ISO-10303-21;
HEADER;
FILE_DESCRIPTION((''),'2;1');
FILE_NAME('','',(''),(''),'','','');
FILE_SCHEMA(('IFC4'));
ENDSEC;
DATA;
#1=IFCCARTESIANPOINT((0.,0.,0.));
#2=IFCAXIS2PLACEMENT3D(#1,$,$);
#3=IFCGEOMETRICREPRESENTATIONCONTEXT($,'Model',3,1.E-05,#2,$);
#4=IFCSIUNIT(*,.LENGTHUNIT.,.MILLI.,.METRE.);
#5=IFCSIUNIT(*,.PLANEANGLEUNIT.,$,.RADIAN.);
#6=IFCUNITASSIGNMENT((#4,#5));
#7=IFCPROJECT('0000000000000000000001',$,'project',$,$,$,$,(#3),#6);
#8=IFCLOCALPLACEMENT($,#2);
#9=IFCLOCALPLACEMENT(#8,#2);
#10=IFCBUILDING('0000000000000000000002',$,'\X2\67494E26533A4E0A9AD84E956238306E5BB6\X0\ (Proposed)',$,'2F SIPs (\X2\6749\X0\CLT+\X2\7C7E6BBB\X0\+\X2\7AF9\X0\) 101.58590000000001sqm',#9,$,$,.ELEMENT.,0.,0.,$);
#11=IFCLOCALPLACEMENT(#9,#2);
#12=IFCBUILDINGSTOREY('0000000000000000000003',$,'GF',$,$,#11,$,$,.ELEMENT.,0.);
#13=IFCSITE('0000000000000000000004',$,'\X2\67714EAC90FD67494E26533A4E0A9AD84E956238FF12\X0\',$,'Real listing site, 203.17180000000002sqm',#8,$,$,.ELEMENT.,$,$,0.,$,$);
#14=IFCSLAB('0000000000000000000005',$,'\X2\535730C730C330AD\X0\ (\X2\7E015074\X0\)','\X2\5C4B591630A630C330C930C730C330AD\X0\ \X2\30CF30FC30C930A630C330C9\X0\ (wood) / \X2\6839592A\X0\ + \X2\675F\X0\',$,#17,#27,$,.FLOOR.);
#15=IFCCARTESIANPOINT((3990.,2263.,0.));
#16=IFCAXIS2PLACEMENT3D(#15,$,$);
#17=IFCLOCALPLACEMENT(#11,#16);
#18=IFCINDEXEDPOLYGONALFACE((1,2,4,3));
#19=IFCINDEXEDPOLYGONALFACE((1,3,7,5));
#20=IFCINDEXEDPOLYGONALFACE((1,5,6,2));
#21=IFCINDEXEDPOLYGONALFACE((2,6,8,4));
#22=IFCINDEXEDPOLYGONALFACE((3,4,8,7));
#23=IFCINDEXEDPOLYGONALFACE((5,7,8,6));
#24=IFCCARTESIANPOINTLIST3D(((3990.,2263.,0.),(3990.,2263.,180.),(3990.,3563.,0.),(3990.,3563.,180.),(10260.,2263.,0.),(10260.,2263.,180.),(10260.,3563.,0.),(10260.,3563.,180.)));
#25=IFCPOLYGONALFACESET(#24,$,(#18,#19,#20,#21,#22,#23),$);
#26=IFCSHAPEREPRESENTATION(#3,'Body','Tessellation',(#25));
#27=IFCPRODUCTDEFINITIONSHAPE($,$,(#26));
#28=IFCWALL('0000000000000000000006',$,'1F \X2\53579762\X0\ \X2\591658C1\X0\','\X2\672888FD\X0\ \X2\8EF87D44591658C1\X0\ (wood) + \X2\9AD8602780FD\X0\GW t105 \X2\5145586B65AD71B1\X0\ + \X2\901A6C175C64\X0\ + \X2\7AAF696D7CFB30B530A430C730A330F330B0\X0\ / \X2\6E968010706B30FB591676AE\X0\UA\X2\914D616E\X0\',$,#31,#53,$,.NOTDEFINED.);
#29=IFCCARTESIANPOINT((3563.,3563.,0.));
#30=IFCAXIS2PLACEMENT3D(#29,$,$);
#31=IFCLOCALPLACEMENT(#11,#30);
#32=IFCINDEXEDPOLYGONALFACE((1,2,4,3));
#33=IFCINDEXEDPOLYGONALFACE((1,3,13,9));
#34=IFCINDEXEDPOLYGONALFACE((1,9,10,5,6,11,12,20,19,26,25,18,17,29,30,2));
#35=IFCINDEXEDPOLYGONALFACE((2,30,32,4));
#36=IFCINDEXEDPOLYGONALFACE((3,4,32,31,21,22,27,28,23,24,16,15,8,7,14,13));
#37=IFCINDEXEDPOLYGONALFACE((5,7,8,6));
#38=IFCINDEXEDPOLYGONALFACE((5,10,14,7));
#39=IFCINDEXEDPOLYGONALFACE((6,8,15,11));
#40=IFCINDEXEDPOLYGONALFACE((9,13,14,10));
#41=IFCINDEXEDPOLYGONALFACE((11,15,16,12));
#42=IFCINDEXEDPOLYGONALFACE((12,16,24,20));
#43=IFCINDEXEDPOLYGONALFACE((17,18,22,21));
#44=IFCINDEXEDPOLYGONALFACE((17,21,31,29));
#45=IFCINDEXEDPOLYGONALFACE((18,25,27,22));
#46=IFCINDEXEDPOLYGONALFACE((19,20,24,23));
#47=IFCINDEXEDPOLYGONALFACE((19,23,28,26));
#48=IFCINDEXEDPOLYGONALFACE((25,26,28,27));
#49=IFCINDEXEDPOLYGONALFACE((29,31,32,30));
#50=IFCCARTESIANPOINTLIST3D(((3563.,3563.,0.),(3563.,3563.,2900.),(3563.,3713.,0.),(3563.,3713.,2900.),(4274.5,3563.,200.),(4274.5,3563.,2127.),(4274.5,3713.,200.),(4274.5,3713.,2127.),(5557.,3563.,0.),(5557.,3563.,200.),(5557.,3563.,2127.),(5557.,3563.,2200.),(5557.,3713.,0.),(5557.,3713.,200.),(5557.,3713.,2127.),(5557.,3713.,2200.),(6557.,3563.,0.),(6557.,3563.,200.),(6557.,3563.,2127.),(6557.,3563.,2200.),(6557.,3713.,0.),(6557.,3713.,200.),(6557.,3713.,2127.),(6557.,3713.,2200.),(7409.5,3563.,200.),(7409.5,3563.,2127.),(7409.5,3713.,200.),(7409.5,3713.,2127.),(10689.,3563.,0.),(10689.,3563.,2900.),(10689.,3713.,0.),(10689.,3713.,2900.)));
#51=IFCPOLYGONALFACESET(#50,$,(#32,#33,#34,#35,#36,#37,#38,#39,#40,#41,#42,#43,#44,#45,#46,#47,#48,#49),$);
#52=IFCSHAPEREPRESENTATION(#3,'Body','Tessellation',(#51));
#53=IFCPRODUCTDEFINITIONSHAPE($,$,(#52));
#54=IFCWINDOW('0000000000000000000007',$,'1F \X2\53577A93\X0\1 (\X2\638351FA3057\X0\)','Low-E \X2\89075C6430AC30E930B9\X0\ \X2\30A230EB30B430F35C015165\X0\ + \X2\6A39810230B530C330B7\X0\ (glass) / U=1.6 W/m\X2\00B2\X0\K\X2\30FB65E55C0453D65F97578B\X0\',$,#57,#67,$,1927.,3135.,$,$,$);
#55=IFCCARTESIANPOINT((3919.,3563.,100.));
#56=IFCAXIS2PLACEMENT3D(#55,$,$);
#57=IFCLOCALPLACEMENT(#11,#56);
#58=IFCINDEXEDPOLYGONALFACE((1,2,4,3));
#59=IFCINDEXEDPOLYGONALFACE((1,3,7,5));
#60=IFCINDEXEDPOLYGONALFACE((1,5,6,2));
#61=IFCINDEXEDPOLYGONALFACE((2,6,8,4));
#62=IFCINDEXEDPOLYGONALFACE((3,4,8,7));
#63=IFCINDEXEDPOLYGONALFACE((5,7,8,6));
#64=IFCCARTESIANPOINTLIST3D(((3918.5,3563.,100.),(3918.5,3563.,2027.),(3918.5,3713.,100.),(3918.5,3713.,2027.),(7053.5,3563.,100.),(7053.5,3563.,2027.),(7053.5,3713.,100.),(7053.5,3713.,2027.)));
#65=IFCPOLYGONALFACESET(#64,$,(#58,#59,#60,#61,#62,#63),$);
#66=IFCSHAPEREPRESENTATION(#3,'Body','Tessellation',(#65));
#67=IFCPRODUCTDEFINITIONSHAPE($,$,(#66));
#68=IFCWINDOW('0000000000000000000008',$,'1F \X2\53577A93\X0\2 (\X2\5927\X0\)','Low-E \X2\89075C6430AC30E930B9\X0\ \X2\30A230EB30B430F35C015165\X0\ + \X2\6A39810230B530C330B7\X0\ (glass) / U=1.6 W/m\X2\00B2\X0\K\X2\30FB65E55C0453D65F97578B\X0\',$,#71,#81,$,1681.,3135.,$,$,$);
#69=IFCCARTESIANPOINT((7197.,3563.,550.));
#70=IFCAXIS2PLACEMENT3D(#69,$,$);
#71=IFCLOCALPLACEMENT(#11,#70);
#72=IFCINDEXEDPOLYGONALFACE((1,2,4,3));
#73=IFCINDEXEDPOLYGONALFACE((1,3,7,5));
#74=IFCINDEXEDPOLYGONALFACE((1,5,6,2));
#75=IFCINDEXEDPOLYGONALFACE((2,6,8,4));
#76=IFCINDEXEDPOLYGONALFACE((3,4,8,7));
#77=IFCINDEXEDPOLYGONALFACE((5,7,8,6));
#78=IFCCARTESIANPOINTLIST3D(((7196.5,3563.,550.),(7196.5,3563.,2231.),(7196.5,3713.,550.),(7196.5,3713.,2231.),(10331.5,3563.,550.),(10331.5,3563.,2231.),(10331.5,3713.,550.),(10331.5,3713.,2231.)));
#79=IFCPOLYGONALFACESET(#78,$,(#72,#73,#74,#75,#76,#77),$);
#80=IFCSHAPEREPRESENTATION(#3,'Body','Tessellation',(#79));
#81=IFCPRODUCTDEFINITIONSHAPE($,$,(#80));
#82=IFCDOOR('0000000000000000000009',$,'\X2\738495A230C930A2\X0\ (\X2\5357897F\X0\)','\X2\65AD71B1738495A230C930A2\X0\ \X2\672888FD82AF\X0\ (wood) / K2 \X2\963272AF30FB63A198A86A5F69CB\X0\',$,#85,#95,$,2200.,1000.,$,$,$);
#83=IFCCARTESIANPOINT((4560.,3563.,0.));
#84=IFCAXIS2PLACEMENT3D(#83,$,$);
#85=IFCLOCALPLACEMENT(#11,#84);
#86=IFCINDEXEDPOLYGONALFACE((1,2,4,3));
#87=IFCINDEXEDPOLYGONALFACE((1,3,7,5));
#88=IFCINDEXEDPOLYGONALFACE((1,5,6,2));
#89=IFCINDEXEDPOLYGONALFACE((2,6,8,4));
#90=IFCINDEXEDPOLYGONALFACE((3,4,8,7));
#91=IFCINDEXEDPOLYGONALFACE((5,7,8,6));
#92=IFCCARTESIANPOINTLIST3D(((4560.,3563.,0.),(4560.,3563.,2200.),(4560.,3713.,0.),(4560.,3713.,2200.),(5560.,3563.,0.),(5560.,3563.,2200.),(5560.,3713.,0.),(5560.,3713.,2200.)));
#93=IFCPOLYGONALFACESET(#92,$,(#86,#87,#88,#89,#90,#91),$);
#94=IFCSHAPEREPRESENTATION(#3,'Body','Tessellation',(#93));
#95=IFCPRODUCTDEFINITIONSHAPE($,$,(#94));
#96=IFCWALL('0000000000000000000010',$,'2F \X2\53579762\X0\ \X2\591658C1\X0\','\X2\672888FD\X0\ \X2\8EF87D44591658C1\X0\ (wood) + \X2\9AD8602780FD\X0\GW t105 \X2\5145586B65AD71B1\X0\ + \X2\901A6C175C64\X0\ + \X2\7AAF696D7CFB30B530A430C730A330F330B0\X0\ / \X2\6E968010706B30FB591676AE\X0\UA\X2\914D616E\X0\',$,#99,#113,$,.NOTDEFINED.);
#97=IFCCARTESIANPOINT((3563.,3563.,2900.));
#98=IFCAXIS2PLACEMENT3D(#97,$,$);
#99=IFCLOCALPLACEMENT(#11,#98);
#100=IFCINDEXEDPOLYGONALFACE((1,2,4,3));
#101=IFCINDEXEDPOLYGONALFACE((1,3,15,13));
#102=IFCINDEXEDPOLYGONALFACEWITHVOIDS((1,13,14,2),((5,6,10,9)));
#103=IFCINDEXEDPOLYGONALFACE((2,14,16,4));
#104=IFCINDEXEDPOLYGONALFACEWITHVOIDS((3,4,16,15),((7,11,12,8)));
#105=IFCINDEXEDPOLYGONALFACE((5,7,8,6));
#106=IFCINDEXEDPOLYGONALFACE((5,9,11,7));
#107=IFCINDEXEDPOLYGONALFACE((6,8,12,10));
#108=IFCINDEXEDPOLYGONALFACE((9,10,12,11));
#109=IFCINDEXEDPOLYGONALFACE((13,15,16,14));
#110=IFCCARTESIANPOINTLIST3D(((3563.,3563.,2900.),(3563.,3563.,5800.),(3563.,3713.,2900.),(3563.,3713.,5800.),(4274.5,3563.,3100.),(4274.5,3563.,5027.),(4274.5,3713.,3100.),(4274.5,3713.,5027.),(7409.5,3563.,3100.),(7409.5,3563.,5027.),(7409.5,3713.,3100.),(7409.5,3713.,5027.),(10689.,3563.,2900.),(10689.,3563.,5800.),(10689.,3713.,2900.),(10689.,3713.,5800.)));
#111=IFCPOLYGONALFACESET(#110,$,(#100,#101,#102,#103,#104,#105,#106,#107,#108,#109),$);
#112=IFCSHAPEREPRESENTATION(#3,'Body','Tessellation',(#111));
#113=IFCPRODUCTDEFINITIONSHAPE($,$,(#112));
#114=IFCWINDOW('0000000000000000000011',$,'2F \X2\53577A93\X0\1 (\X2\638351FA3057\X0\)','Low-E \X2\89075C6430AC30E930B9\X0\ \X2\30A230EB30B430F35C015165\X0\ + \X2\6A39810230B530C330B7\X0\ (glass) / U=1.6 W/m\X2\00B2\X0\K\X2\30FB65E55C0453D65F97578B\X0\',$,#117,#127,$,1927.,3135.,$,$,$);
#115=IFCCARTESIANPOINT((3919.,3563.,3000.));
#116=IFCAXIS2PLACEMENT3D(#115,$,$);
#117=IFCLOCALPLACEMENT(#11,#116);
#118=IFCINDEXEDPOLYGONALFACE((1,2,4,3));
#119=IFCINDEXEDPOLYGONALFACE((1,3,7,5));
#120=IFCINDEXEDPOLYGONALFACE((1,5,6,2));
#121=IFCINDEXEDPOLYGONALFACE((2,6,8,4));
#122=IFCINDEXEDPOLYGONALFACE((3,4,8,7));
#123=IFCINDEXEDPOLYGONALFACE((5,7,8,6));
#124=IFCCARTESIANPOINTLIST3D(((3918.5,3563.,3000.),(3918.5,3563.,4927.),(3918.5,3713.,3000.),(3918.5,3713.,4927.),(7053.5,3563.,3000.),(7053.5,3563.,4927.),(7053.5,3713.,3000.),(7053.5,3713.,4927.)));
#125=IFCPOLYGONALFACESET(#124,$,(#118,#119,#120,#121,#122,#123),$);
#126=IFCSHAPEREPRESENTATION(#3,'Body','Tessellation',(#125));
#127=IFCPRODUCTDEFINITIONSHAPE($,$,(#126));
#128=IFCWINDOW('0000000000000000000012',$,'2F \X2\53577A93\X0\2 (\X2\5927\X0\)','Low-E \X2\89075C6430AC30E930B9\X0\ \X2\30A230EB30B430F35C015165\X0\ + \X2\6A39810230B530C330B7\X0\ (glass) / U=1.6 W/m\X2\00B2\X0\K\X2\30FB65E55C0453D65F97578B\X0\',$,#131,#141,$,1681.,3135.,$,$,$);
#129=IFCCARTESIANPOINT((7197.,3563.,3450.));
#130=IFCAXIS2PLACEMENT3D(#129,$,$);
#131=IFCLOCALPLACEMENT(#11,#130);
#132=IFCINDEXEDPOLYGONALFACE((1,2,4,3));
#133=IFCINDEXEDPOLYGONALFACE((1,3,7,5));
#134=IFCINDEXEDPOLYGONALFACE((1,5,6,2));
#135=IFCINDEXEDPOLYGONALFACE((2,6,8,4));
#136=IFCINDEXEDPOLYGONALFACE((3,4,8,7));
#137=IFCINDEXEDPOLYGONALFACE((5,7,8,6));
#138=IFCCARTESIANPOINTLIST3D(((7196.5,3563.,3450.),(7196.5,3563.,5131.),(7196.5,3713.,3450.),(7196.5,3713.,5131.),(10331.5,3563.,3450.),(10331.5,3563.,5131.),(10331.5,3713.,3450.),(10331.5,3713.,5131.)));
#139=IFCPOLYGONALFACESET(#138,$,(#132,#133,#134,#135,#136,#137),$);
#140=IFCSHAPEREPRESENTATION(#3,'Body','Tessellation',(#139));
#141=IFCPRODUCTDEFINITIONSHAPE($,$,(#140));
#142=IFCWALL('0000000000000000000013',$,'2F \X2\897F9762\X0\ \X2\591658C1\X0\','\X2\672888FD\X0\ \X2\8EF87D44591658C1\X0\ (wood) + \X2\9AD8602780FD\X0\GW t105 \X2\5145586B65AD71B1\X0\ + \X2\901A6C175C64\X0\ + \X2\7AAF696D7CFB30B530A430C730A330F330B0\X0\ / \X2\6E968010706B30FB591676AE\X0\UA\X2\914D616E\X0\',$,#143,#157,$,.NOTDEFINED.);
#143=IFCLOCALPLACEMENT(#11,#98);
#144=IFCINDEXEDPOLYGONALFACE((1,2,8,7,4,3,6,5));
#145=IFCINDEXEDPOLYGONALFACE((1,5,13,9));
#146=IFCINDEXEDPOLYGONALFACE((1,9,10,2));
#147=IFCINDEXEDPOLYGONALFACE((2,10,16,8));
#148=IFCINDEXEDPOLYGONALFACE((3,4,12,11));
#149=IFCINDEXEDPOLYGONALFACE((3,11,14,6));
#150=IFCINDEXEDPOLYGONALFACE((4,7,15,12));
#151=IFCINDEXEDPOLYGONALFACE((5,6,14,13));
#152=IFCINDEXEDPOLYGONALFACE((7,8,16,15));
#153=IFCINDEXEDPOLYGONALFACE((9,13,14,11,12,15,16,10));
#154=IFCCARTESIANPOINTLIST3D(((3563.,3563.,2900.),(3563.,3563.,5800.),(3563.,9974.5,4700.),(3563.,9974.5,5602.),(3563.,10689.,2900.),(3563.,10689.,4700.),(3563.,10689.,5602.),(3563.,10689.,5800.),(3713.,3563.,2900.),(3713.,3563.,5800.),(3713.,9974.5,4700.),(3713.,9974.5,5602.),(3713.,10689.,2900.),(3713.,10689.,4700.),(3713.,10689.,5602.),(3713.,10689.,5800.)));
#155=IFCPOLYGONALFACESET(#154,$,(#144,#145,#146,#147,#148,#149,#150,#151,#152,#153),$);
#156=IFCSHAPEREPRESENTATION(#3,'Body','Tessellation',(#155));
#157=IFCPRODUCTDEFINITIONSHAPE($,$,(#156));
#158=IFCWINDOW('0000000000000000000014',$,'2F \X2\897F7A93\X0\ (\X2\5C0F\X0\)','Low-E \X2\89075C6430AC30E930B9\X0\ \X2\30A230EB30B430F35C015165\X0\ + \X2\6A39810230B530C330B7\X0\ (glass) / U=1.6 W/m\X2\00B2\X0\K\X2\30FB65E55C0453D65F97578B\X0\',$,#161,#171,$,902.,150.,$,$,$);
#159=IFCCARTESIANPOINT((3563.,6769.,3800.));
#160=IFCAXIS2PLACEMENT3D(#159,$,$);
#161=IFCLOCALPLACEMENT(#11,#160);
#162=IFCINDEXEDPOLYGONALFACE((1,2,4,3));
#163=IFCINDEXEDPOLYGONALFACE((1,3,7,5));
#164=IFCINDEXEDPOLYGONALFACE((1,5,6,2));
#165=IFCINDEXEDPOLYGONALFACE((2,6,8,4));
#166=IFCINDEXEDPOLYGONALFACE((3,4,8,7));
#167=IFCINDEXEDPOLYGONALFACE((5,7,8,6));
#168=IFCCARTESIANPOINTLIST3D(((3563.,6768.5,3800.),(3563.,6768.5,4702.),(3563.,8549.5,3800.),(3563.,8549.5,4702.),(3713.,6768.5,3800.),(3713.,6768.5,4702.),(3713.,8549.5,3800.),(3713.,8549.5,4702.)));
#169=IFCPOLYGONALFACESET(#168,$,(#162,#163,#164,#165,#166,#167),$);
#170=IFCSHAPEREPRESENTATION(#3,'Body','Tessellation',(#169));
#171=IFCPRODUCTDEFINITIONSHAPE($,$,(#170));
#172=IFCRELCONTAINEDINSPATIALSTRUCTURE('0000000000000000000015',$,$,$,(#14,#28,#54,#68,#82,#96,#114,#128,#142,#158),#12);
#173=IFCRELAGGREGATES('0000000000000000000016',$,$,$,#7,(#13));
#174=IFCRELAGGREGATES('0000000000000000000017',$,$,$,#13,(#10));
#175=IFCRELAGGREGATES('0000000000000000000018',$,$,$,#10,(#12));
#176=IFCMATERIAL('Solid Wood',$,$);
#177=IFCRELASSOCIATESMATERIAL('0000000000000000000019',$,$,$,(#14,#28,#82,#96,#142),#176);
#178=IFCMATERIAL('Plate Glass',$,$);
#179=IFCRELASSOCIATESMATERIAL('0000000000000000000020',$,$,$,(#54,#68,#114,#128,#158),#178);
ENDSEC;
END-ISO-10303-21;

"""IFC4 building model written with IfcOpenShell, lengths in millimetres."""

from ifc_helpers import new_model, si_unit, frame, frame_2d, origin, place, context, project, spatial, rectangle, extrude, material, element, fill, save


model = new_model("IFC4")

# Units and contexts
model_context = context("Model", 3, precision=1e-05, world=origin())
ifc_project = project(units=[si_unit("LENGTHUNIT", "METRE", prefix="MILLI"), si_unit("PLANEANGLEUNIT", "RADIAN")], contexts=[model_context])

# Site, building, storey
site_placement = place(None, origin())
site = spatial("IfcSite", under=ifc_project, at=site_placement, Name="東京都杉並区上高井戸２", ObjectType="Real listing site, 203.17180000000002sqm", CompositionType="ELEMENT", RefElevation=0.0)
building_placement = place(site_placement, origin())
building = spatial("IfcBuilding", under=site, at=building_placement, Name="杉並区上高井戸の家 (Proposed)", ObjectType="2F SIPs (杉CLT+籾殻+竹) 101.58590000000001sqm", CompositionType="ELEMENT", ElevationOfRefHeight=0.0, ElevationOfTerrain=0.0)
storey_placement = place(building_placement, origin())
storey = spatial("IfcBuildingStorey", under=building, at=storey_placement, Name="GF", CompositionType="ELEMENT", Elevation=0.0)

# Slab
ifc_material_1 = material(Name="Solid Wood")
slab_1_placement = place(storey_placement, frame((3990.0, 2263.0, 0.0)))
element("IfcSlab", 1, at=slab_1_placement, inside=storey, material=ifc_material_1, Name="南デッキ (縁側)", Description="屋外ウッドデッキ ハードウッド (wood) / 根太 + 束", PredefinedType="FLOOR", context=model_context, shape_type="SweptSolid", body=[
    extrude(rectangle(XDim=6270.0, YDim=1300.0, at=frame_2d((3135.0, 650.0))), frame((3990.0, 2263.0, 0.0)), (0.0, 0.0, 1.0), 180.0),
])

# Wall, openings, windows, door
wall_1_placement = place(storey_placement, frame((3563.0, 3563.0, 0.0)))
wall_1 = element("IfcWall", 2, at=wall_1_placement, inside=storey, material=ifc_material_1, Name="1F 南面 外壁", Description="木製 軸組外壁 (wood) + 高性能GW t105 充填断熱 + 通気層 + 窯業系サイディング / 準耐火・外皮UA配慮", PredefinedType="NOTDEFINED", context=model_context, shape_type="SweptSolid", body=[
    extrude(rectangle(XDim=7126.0, YDim=150.0, at=frame_2d((3563.0, 75.0))), frame((3563.0, 3563.0, 0.0)), (0.0, 0.0, 1.0), 2900.0),
])
opening_1_placement = place(storey_placement, frame((3919.0, 3563.0, 100.0)))
opening_1 = element("IfcOpeningElement", 3, at=opening_1_placement, cuts=wall_1, PredefinedType="NOTDEFINED", context=model_context, shape_type="SweptSolid", body=[
    extrude(rectangle(XDim=3135.0, YDim=150.0, at=frame_2d((1567.0, 75.0))), frame((3919.0, 3563.0, 100.0)), (0.0, 0.0, 1.0), 1927.0),
])
opening_2_placement = place(storey_placement, frame((7197.0, 3563.0, 550.0)))
opening_2 = element("IfcOpeningElement", 4, at=opening_2_placement, cuts=wall_1, PredefinedType="NOTDEFINED", context=model_context, shape_type="SweptSolid", body=[
    extrude(rectangle(XDim=3135.0, YDim=150.0, at=frame_2d((1567.0, 75.0))), frame((7197.0, 3563.0, 550.0)), (0.0, 0.0, 1.0), 1681.0),
])
opening_3_placement = place(storey_placement, frame((4560.0, 3563.0, 0.0)))
opening_3 = element("IfcOpeningElement", 5, at=opening_3_placement, cuts=wall_1, PredefinedType="NOTDEFINED", context=model_context, shape_type="SweptSolid", body=[
    extrude(rectangle(XDim=1000.0, YDim=150.0, at=frame_2d((500.0, 75.0))), frame((4560.0, 3563.0, 0.0)), (0.0, 0.0, 1.0), 2200.0),
])
ifc_material_2 = material(Name="Plate Glass")
window_1_placement = place(storey_placement, frame((3919.0, 3563.0, 100.0)))
window_1 = element("IfcWindow", 6, at=window_1_placement, inside=storey, material=ifc_material_2, Name="1F 南窓1 (掃出し)", Description="Low-E 複層ガラス アルゴン封入 + 樹脂サッシ (glass) / U=1.6 W/m²K・日射取得型", OverallHeight=1927.0, OverallWidth=3135.0, context=model_context, shape_type="SweptSolid", body=[
    extrude(rectangle(XDim=3135.0, YDim=150.0, at=frame_2d((1567.0, 75.0))), frame((3919.0, 3563.0, 100.0)), (0.0, 0.0, 1.0), 1927.0),
])
fill(opening_1, window_1)
window_2_placement = place(storey_placement, frame((7197.0, 3563.0, 550.0)))
window_2 = element("IfcWindow", 7, at=window_2_placement, inside=storey, material=ifc_material_2, Name="1F 南窓2 (大)", Description="Low-E 複層ガラス アルゴン封入 + 樹脂サッシ (glass) / U=1.6 W/m²K・日射取得型", OverallHeight=1681.0, OverallWidth=3135.0, context=model_context, shape_type="SweptSolid", body=[
    extrude(rectangle(XDim=3135.0, YDim=150.0, at=frame_2d((1567.0, 75.0))), frame((7197.0, 3563.0, 550.0)), (0.0, 0.0, 1.0), 1681.0),
])
fill(opening_2, window_2)
door_placement = place(storey_placement, frame((4560.0, 3563.0, 0.0)))
door = element("IfcDoor", 8, at=door_placement, inside=storey, material=ifc_material_1, Name="玄関ドア (南西)", Description="断熱玄関ドア 木製芯 (wood) / K2 防犯・採風機構", OverallHeight=2200.0, OverallWidth=1000.0, context=model_context, shape_type="SweptSolid", body=[
    extrude(rectangle(XDim=1000.0, YDim=150.0, at=frame_2d((500.0, 75.0))), frame((4560.0, 3563.0, 0.0)), (0.0, 0.0, 1.0), 2200.0),
])
fill(opening_3, door)

# Wall, openings, windows
wall_2_placement = place(storey_placement, frame((3563.0, 3563.0, 2900.0)))
wall_2 = element("IfcWall", 9, at=wall_2_placement, inside=storey, material=ifc_material_1, Name="2F 南面 外壁", Description="木製 軸組外壁 (wood) + 高性能GW t105 充填断熱 + 通気層 + 窯業系サイディング / 準耐火・外皮UA配慮", PredefinedType="NOTDEFINED", context=model_context, shape_type="SweptSolid", body=[
    extrude(rectangle(XDim=7126.0, YDim=150.0, at=frame_2d((3563.0, 75.0))), frame((3563.0, 3563.0, 2900.0)), (0.0, 0.0, 1.0), 2900.0),
])
opening_4_placement = place(storey_placement, frame((3919.0, 3563.0, 3000.0)))
opening_4 = element("IfcOpeningElement", 10, at=opening_4_placement, cuts=wall_2, PredefinedType="NOTDEFINED", context=model_context, shape_type="SweptSolid", body=[
    extrude(rectangle(XDim=3135.0, YDim=150.0, at=frame_2d((1567.0, 75.0))), frame((3919.0, 3563.0, 3000.0)), (0.0, 0.0, 1.0), 1927.0),
])
opening_5_placement = place(storey_placement, frame((7197.0, 3563.0, 3450.0)))
opening_5 = element("IfcOpeningElement", 11, at=opening_5_placement, cuts=wall_2, PredefinedType="NOTDEFINED", context=model_context, shape_type="SweptSolid", body=[
    extrude(rectangle(XDim=3135.0, YDim=150.0, at=frame_2d((1567.0, 75.0))), frame((7197.0, 3563.0, 3450.0)), (0.0, 0.0, 1.0), 1681.0),
])
window_3_placement = place(storey_placement, frame((3919.0, 3563.0, 3000.0)))
window_3 = element("IfcWindow", 12, at=window_3_placement, inside=storey, material=ifc_material_2, Name="2F 南窓1 (掃出し)", Description="Low-E 複層ガラス アルゴン封入 + 樹脂サッシ (glass) / U=1.6 W/m²K・日射取得型", OverallHeight=1927.0, OverallWidth=3135.0, context=model_context, shape_type="SweptSolid", body=[
    extrude(rectangle(XDim=3135.0, YDim=150.0, at=frame_2d((1567.0, 75.0))), frame((3919.0, 3563.0, 3000.0)), (0.0, 0.0, 1.0), 1927.0),
])
fill(opening_4, window_3)
window_4_placement = place(storey_placement, frame((7197.0, 3563.0, 3450.0)))
window_4 = element("IfcWindow", 13, at=window_4_placement, inside=storey, material=ifc_material_2, Name="2F 南窓2 (大)", Description="Low-E 複層ガラス アルゴン封入 + 樹脂サッシ (glass) / U=1.6 W/m²K・日射取得型", OverallHeight=1681.0, OverallWidth=3135.0, context=model_context, shape_type="SweptSolid", body=[
    extrude(rectangle(XDim=3135.0, YDim=150.0, at=frame_2d((1567.0, 75.0))), frame((7197.0, 3563.0, 3450.0)), (0.0, 0.0, 1.0), 1681.0),
])
fill(opening_5, window_4)

# Wall, opening, window
wall_3_placement = place(storey_placement, frame((3563.0, 3563.0, 2900.0)))
wall_3 = element("IfcWall", 14, at=wall_3_placement, inside=storey, material=ifc_material_1, Name="2F 西面 外壁", Description="木製 軸組外壁 (wood) + 高性能GW t105 充填断熱 + 通気層 + 窯業系サイディング / 準耐火・外皮UA配慮", PredefinedType="NOTDEFINED", context=model_context, shape_type="SweptSolid", body=[
    extrude(rectangle(XDim=150.0, YDim=7126.0, at=frame_2d((75.0, 3563.0))), frame((3563.0, 3563.0, 2900.0)), (0.0, 0.0, 1.0), 2900.0),
])
opening_6_placement = place(storey_placement, frame((3563.0, 6769.0, 3800.0)))
opening_6 = element("IfcOpeningElement", 15, at=opening_6_placement, cuts=wall_3, PredefinedType="NOTDEFINED", context=model_context, shape_type="SweptSolid", body=[
    extrude(rectangle(XDim=150.0, YDim=1781.0, at=frame_2d((75.0, 890.0))), frame((3563.0, 6769.0, 3800.0)), (0.0, 0.0, 1.0), 902.0),
])
window_5_placement = place(storey_placement, frame((3563.0, 6769.0, 3800.0)))
window_5 = element("IfcWindow", 16, at=window_5_placement, inside=storey, material=ifc_material_2, Name="2F 西窓 (小)", Description="Low-E 複層ガラス アルゴン封入 + 樹脂サッシ (glass) / U=1.6 W/m²K・日射取得型", OverallHeight=902.0, OverallWidth=150.0, context=model_context, shape_type="SweptSolid", body=[
    extrude(rectangle(XDim=150.0, YDim=1781.0, at=frame_2d((75.0, 890.0))), frame((3563.0, 6769.0, 3800.0)), (0.0, 0.0, 1.0), 902.0),
])
fill(opening_6, window_5)

save(model, "model.ifc")
